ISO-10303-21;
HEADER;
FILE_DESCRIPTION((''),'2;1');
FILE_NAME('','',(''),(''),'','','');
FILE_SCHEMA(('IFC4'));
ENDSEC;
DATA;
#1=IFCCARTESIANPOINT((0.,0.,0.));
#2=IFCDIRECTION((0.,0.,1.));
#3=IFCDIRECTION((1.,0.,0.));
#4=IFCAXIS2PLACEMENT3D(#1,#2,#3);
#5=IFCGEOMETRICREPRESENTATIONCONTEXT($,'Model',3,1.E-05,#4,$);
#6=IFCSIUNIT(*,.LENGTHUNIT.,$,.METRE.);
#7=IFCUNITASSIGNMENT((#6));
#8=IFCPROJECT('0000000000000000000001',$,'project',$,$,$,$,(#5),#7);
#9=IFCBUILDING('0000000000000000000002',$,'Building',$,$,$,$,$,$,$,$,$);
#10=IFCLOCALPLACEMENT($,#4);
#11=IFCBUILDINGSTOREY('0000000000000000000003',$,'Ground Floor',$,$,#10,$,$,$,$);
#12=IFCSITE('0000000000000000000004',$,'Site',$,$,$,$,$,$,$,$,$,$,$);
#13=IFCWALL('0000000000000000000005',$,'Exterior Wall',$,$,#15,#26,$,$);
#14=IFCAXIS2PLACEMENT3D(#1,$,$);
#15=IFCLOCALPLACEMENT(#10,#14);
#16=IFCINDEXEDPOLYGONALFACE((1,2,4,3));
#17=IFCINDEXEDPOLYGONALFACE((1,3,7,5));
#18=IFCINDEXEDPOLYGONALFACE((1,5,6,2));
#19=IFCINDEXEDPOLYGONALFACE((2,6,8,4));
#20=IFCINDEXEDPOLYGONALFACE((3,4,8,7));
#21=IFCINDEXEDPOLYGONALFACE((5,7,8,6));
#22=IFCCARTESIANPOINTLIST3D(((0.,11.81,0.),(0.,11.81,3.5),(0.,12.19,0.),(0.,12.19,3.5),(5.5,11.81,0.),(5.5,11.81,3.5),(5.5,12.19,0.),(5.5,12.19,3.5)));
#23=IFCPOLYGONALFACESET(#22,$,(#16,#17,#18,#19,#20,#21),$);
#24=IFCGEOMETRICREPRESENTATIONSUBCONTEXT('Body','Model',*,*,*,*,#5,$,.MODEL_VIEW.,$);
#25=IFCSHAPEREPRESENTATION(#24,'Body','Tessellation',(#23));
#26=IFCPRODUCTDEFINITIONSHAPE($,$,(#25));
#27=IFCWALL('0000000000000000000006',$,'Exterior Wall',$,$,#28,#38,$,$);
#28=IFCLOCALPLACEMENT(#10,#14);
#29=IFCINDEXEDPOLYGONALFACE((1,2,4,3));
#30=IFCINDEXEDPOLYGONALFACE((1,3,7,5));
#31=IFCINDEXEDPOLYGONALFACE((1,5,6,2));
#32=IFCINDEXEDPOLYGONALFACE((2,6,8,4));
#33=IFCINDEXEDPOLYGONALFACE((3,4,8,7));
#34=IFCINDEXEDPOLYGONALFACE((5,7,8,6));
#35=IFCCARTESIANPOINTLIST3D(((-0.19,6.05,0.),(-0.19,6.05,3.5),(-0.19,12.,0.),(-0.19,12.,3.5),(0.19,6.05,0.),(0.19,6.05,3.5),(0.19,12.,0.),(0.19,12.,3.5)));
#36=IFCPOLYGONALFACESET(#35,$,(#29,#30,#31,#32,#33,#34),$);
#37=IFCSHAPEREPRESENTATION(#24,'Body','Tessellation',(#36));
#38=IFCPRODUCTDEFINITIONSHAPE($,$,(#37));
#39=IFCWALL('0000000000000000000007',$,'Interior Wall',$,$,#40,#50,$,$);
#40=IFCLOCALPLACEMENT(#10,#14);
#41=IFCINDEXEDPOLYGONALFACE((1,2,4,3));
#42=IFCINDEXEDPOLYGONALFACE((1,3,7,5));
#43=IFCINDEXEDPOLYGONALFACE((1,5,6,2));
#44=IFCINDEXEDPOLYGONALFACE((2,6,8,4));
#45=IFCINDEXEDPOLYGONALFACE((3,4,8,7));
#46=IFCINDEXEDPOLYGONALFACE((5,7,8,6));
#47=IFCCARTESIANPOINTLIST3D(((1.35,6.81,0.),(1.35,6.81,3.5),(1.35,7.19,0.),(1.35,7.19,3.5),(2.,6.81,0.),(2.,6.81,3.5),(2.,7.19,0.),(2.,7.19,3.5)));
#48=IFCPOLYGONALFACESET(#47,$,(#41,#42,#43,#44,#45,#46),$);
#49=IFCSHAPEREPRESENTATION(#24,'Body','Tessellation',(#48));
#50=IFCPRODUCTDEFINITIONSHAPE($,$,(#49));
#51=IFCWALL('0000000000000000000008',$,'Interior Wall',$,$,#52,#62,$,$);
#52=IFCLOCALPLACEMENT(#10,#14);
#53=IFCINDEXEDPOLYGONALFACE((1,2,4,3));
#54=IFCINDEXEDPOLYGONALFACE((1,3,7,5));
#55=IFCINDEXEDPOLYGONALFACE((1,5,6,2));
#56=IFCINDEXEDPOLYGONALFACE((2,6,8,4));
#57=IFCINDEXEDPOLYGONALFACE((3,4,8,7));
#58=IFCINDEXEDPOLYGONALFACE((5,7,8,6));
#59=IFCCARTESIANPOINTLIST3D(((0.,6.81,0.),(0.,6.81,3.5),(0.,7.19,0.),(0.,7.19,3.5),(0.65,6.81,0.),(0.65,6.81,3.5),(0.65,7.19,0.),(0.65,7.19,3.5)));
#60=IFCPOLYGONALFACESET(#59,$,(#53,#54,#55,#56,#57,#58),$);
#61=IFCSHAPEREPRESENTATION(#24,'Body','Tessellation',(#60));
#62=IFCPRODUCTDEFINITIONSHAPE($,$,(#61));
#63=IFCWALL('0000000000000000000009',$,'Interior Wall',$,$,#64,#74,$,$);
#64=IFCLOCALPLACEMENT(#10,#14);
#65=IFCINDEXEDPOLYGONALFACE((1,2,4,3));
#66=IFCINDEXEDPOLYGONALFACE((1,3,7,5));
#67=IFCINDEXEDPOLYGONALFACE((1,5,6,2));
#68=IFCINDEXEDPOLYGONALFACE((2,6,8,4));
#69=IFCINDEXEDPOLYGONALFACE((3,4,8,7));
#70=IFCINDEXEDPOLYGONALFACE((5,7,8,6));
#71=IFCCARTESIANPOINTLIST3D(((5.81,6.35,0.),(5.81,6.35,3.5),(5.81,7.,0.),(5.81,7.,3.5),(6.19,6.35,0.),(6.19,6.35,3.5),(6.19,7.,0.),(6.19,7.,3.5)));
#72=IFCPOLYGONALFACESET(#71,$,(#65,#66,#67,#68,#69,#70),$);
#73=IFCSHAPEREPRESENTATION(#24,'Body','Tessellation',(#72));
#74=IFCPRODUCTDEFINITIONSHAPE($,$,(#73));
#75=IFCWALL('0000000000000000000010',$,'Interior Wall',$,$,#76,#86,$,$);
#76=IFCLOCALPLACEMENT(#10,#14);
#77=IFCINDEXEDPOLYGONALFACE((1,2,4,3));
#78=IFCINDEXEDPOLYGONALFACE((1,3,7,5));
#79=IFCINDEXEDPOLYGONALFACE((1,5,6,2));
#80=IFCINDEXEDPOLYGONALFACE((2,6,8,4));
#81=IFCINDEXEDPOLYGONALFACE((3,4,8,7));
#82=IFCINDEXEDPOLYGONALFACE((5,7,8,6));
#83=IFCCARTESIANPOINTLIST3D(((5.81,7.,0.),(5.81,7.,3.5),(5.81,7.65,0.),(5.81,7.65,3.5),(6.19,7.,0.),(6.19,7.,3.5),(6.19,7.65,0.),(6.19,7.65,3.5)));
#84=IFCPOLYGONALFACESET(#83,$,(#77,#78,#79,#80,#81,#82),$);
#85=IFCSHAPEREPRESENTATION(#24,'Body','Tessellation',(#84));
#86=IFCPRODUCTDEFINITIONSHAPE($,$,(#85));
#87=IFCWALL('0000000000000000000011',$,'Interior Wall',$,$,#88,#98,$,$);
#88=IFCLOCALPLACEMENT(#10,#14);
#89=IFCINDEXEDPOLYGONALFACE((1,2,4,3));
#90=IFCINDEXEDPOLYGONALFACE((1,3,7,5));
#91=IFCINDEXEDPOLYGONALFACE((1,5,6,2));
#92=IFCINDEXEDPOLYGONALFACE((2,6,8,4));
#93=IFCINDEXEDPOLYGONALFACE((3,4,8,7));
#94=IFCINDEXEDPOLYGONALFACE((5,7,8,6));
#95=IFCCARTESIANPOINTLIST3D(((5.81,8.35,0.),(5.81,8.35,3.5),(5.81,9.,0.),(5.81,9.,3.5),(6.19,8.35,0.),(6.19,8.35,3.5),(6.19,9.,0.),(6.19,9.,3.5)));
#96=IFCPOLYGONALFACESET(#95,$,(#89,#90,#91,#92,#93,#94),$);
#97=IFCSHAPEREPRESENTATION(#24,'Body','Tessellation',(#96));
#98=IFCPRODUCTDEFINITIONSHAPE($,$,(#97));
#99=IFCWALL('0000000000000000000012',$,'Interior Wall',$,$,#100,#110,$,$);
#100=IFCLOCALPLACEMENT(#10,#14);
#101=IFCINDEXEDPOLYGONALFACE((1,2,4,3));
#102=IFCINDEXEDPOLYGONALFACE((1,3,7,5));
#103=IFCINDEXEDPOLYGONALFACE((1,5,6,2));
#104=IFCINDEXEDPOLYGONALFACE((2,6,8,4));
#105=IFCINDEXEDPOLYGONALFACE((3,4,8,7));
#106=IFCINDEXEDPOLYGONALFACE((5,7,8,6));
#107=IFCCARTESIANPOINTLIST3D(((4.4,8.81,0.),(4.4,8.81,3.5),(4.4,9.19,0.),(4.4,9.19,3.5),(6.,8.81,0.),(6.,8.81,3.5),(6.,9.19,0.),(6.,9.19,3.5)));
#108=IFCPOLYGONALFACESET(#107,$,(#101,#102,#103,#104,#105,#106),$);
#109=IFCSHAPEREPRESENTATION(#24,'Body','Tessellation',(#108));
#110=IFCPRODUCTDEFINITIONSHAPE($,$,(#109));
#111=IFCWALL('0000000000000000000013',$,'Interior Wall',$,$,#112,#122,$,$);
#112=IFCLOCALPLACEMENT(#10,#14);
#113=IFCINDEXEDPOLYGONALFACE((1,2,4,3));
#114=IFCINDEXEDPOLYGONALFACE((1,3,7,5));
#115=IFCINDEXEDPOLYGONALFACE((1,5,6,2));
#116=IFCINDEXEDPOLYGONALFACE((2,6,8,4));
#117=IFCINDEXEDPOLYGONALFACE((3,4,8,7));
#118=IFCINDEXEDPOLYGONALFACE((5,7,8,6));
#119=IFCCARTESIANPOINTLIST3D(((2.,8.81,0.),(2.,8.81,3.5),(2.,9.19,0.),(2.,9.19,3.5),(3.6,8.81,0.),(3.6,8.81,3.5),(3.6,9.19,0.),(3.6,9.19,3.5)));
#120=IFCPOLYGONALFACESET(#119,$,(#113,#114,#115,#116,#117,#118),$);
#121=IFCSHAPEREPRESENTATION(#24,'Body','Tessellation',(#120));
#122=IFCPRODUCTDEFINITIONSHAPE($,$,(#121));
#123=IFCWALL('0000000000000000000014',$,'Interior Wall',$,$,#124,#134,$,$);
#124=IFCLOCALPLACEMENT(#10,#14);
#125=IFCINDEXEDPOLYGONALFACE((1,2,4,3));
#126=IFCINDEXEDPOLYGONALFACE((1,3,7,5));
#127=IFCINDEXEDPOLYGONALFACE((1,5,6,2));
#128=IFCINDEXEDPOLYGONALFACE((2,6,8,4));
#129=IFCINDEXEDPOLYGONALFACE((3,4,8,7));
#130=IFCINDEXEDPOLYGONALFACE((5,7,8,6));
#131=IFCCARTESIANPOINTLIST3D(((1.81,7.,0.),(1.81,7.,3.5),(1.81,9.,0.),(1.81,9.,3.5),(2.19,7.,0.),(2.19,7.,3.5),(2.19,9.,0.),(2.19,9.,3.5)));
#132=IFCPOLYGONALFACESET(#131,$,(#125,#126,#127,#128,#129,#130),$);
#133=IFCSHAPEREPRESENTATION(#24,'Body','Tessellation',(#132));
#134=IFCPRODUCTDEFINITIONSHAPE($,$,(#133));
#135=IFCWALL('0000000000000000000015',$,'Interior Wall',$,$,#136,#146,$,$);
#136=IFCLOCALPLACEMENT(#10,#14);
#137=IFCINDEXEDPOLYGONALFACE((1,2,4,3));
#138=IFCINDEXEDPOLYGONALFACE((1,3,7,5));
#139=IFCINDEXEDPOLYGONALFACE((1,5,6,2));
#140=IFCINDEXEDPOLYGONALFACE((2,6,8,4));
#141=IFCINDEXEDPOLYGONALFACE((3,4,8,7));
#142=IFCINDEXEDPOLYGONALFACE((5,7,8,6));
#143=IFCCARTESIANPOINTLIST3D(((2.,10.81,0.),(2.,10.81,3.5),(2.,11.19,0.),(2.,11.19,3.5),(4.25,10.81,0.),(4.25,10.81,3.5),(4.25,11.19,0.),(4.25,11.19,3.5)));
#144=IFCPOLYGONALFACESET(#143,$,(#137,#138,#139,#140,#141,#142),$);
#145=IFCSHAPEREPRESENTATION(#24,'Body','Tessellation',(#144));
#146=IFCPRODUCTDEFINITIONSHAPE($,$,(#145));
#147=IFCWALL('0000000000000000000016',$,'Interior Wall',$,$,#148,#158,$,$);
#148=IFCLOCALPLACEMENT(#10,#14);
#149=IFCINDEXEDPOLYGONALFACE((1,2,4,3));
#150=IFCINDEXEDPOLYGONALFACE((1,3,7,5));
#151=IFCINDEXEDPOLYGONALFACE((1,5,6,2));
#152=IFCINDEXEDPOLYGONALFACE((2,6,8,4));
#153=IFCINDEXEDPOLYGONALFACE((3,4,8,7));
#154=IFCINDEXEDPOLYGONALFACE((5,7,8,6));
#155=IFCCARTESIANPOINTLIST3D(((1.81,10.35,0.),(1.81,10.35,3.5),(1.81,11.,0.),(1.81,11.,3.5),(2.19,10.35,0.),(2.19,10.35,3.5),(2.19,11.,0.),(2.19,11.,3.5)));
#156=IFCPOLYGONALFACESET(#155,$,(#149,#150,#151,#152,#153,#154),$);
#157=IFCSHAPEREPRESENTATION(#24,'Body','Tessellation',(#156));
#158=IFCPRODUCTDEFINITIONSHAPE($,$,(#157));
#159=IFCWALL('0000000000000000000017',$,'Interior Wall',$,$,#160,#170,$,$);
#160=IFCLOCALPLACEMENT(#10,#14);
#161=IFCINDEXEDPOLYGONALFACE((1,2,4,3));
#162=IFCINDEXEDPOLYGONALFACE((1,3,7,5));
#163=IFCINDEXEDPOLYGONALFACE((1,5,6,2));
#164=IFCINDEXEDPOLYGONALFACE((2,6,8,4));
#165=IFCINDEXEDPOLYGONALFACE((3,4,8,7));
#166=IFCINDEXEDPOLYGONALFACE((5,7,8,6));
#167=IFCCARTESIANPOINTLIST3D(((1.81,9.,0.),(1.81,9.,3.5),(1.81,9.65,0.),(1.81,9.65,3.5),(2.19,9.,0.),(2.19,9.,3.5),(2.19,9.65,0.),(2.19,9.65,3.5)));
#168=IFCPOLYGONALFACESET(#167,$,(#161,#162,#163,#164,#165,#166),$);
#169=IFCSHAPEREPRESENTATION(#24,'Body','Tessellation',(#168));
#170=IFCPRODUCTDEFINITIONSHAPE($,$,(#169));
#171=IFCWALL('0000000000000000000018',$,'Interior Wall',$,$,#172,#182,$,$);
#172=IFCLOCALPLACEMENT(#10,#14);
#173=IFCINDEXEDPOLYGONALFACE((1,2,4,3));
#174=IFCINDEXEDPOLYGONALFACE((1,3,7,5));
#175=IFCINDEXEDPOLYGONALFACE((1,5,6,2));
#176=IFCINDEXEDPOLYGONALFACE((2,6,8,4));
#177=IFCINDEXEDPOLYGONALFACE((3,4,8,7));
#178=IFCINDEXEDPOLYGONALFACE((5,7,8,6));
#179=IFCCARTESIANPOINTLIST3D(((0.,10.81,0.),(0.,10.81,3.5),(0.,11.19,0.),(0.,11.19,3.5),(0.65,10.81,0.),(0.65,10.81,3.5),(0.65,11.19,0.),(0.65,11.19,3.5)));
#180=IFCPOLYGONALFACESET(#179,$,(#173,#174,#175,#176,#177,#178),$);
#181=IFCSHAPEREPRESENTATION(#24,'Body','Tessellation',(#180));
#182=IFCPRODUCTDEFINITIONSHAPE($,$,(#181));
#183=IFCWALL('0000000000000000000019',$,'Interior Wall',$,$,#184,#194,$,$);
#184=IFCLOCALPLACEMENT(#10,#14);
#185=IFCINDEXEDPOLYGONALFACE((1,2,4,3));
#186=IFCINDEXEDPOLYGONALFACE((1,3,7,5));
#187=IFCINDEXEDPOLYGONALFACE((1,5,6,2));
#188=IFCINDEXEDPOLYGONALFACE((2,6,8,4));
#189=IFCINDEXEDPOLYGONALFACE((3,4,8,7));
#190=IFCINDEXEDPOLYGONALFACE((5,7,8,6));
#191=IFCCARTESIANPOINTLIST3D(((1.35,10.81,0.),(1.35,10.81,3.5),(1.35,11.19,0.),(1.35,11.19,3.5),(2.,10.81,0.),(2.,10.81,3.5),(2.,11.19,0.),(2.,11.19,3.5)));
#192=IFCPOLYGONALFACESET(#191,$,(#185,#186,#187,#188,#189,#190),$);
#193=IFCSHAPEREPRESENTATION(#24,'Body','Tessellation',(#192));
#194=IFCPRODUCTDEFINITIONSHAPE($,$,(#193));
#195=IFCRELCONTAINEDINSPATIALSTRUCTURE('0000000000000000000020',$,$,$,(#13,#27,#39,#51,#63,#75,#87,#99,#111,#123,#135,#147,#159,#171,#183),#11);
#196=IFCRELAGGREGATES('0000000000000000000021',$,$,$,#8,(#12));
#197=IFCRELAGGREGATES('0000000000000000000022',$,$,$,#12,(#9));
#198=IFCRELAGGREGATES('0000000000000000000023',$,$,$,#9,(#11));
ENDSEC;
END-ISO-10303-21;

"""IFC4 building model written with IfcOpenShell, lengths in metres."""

from ifc_helpers import new_model, si_unit, frame, origin_with_axes, place, context, subcontext, project, spatial, indexed_curve, outline, extrude, element, save


model = new_model("IFC4")

# Units and contexts
model_context = context("Model", 3, precision=1e-05, world=origin_with_axes())
body_context = subcontext(model_context, "Body", "Model", "MODEL_VIEW")
ifc_project = project(units=[si_unit("LENGTHUNIT", "METRE")], contexts=[model_context])

# Site, building, storey
site = spatial("IfcSite", under=ifc_project, Name="Site")
building = spatial("IfcBuilding", under=site, Name="Building")
storey_placement = place(None, origin_with_axes())
storey = spatial("IfcBuildingStorey", under=building, at=storey_placement, Name="Ground Floor")

# Walls
wall_1_placement = place(storey_placement, frame((5.5, 12.0, 0.0), z_axis=(0.0, 0.0, 1.0), x_axis=(-1.0, 0.0, 0.0)))
element("IfcWall", 1, at=wall_1_placement, inside=storey, Name="Exterior Wall", context=body_context, shape_type="SweptSolid", body=[
    extrude(outline(indexed_curve([(0.0, 0.0), (0.0, 0.38), (5.5, 0.38), (5.5, 0.0), (0.0, 0.0)], self_intersect=False)), frame((0.0, -0.19, 0.0), z_axis=(0.0, 0.0, 1.0), x_axis=(1.0, 0.0, 0.0)), (0.0, 0.0, 1.0), 3.5),
])
wall_2_placement = place(storey_placement, frame((0.0, 12.0, 0.0), z_axis=(0.0, 0.0, 1.0), x_axis=(0.0, -1.0, 0.0)))
element("IfcWall", 2, at=wall_2_placement, inside=storey, Name="Exterior Wall", context=body_context, shape_type="SweptSolid", body=[
    extrude(outline(indexed_curve([(0.0, 0.0), (0.0, 0.38), (5.95, 0.38), (5.95, 0.0), (0.0, 0.0)], self_intersect=False)), frame((0.0, -0.19, 0.0), z_axis=(0.0, 0.0, 1.0), x_axis=(1.0, 0.0, 0.0)), (0.0, 0.0, 1.0), 3.5),
])
for number, where, z_axis, x_axis, name in (
    (3, (2.0, 7.0, 0.0), (0.0, 0.0, 1.0), (-1.0, 0.0, 0.0), "Interior Wall"),
    (4, (0.65, 7.0, 0.0), (0.0, 0.0, 1.0), (-1.0, 0.0, 0.0), "Interior Wall"),
):
    element("IfcWall", number, at=place(storey_placement, frame(where, z_axis=z_axis, x_axis=x_axis)), inside=storey, Name=name, context=body_context, shape_type="SweptSolid", body=[
        extrude(outline(indexed_curve([(0.0, 0.0), (0.0, 0.38), (0.65, 0.38), (0.65, 0.0), (0.0, 0.0)], self_intersect=False)), frame((0.0, -0.19, 0.0), z_axis=(0.0, 0.0, 1.0), x_axis=(1.0, 0.0, 0.0)), (0.0, 0.0, 1.0), 3.5),
    ])
for number, where, z_axis, x_axis, name in (
    (5, (6.0, 6.35, 0.0), (0.0, 0.0, 1.0), (0.0, 1.0, 0.0), "Interior Wall"),
    (6, (6.0, 7.0, 0.0), (0.0, 0.0, 1.0), (0.0, 1.0, 0.0), "Interior Wall"),
    (7, (6.0, 8.35, 0.0), (0.0, 0.0, 1.0), (0.0, 1.0, 0.0), "Interior Wall"),
):
    element("IfcWall", number, at=place(storey_placement, frame(where, z_axis=z_axis, x_axis=x_axis)), inside=storey, Name=name, context=body_context, shape_type="SweptSolid", body=[
        extrude(outline(indexed_curve([(0.0, 0.0), (0.0, 0.38), (0.65, 0.38), (0.65, 0.0), (0.0, 0.0)], self_intersect=False)), frame((0.0, -0.19, 0.0), z_axis=(0.0, 0.0, 1.0), x_axis=(1.0, 0.0, 0.0)), (0.0, 0.0, 1.0), 3.5),
    ])
wall_3_placement = place(storey_placement, frame((6.0, 9.0, 0.0), z_axis=(0.0, 0.0, 1.0), x_axis=(-1.0, 0.0, 0.0)))
element("IfcWall", 8, at=wall_3_placement, inside=storey, Name="Interior Wall", context=body_context, shape_type="SweptSolid", body=[
    extrude(outline(indexed_curve([(0.0, 0.0), (0.0, 0.38), (1.6, 0.38), (1.6, 0.0), (0.0, 0.0)], self_intersect=False)), frame((0.0, -0.19, 0.0), z_axis=(0.0, 0.0, 1.0), x_axis=(1.0, 0.0, 0.0)), (0.0, 0.0, 1.0), 3.5),
])
wall_4_placement = place(storey_placement, frame((3.6, 9.0, 0.0), z_axis=(0.0, 0.0, 1.0), x_axis=(-1.0, 0.0, 0.0)))
element("IfcWall", 9, at=wall_4_placement, inside=storey, Name="Interior Wall", context=body_context, shape_type="SweptSolid", body=[
    extrude(outline(indexed_curve([(0.0, 0.0), (0.0, 0.38), (1.6, 0.38), (1.6, 0.0), (0.0, 0.0)], self_intersect=False)), frame((0.0, -0.19, 0.0), z_axis=(0.0, 0.0, 1.0), x_axis=(1.0, 0.0, 0.0)), (0.0, 0.0, 1.0), 3.5),
])
wall_5_placement = place(storey_placement, frame((2.0, 9.0, 0.0), z_axis=(0.0, 0.0, 1.0), x_axis=(0.0, -1.0, 0.0)))
element("IfcWall", 10, at=wall_5_placement, inside=storey, Name="Interior Wall", context=body_context, shape_type="SweptSolid", body=[
    extrude(outline(indexed_curve([(0.0, 0.0), (0.0, 0.38), (2.0, 0.38), (2.0, 0.0), (0.0, 0.0)], self_intersect=False)), frame((0.0, -0.19, 0.0), z_axis=(0.0, 0.0, 1.0), x_axis=(1.0, 0.0, 0.0)), (0.0, 0.0, 1.0), 3.5),
])
wall_6_placement = place(storey_placement, frame((4.25, 11.0, 0.0), z_axis=(0.0, 0.0, 1.0), x_axis=(-1.0, 0.0, 0.0)))
element("IfcWall", 11, at=wall_6_placement, inside=storey, Name="Interior Wall", context=body_context, shape_type="SweptSolid", body=[
    extrude(outline(indexed_curve([(0.0, 0.0), (0.0, 0.38), (2.25, 0.38), (2.25, 0.0), (0.0, 0.0)], self_intersect=False)), frame((0.0, -0.19, 0.0), z_axis=(0.0, 0.0, 1.0), x_axis=(1.0, 0.0, 0.0)), (0.0, 0.0, 1.0), 3.5),
])
for number, where, z_axis, x_axis, name in (
    (12, (2.0, 11.0, 0.0), (0.0, 0.0, 1.0), (0.0, -1.0, 0.0), "Interior Wall"),
    (13, (2.0, 9.65, 0.0), (0.0, 0.0, 1.0), (0.0, -1.0, 0.0), "Interior Wall"),
):
    element("IfcWall", number, at=place(storey_placement, frame(where, z_axis=z_axis, x_axis=x_axis)), inside=storey, Name=name, context=body_context, shape_type="SweptSolid", body=[
        extrude(outline(indexed_curve([(0.0, 0.0), (0.0, 0.38), (0.65, 0.38), (0.65, 0.0), (0.0, 0.0)], self_intersect=False)), frame((0.0, -0.19, 0.0), z_axis=(0.0, 0.0, 1.0), x_axis=(1.0, 0.0, 0.0)), (0.0, 0.0, 1.0), 3.5),
    ])
wall_7_placement = place(storey_placement, frame((0.0, 11.0, 0.0), z_axis=(0.0, 0.0, 1.0), x_axis=(1.0, 0.0, 0.0)))
element("IfcWall", 14, at=wall_7_placement, inside=storey, Name="Interior Wall", context=body_context, shape_type="SweptSolid", body=[
    extrude(outline(indexed_curve([(0.0, 0.0), (0.0, 0.38), (0.65, 0.38), (0.65, 0.0), (0.0, 0.0)], self_intersect=False)), frame((0.0, -0.19, 0.0), z_axis=(0.0, 0.0, 1.0), x_axis=(1.0, 0.0, 0.0)), (0.0, 0.0, 1.0), 3.5),
])
wall_8_placement = place(storey_placement, frame((1.35, 11.0, 0.0), z_axis=(0.0, 0.0, 1.0), x_axis=(1.0, 0.0, 0.0)))
element("IfcWall", 15, at=wall_8_placement, inside=storey, Name="Interior Wall", context=body_context, shape_type="SweptSolid", body=[
    extrude(outline(indexed_curve([(0.0, 0.0), (0.0, 0.38), (0.65, 0.38), (0.65, 0.0), (0.0, 0.0)], self_intersect=False)), frame((0.0, -0.19, 0.0), z_axis=(0.0, 0.0, 1.0), x_axis=(1.0, 0.0, 0.0)), (0.0, 0.0, 1.0), 3.5),
])

save(model, "model.ifc")
